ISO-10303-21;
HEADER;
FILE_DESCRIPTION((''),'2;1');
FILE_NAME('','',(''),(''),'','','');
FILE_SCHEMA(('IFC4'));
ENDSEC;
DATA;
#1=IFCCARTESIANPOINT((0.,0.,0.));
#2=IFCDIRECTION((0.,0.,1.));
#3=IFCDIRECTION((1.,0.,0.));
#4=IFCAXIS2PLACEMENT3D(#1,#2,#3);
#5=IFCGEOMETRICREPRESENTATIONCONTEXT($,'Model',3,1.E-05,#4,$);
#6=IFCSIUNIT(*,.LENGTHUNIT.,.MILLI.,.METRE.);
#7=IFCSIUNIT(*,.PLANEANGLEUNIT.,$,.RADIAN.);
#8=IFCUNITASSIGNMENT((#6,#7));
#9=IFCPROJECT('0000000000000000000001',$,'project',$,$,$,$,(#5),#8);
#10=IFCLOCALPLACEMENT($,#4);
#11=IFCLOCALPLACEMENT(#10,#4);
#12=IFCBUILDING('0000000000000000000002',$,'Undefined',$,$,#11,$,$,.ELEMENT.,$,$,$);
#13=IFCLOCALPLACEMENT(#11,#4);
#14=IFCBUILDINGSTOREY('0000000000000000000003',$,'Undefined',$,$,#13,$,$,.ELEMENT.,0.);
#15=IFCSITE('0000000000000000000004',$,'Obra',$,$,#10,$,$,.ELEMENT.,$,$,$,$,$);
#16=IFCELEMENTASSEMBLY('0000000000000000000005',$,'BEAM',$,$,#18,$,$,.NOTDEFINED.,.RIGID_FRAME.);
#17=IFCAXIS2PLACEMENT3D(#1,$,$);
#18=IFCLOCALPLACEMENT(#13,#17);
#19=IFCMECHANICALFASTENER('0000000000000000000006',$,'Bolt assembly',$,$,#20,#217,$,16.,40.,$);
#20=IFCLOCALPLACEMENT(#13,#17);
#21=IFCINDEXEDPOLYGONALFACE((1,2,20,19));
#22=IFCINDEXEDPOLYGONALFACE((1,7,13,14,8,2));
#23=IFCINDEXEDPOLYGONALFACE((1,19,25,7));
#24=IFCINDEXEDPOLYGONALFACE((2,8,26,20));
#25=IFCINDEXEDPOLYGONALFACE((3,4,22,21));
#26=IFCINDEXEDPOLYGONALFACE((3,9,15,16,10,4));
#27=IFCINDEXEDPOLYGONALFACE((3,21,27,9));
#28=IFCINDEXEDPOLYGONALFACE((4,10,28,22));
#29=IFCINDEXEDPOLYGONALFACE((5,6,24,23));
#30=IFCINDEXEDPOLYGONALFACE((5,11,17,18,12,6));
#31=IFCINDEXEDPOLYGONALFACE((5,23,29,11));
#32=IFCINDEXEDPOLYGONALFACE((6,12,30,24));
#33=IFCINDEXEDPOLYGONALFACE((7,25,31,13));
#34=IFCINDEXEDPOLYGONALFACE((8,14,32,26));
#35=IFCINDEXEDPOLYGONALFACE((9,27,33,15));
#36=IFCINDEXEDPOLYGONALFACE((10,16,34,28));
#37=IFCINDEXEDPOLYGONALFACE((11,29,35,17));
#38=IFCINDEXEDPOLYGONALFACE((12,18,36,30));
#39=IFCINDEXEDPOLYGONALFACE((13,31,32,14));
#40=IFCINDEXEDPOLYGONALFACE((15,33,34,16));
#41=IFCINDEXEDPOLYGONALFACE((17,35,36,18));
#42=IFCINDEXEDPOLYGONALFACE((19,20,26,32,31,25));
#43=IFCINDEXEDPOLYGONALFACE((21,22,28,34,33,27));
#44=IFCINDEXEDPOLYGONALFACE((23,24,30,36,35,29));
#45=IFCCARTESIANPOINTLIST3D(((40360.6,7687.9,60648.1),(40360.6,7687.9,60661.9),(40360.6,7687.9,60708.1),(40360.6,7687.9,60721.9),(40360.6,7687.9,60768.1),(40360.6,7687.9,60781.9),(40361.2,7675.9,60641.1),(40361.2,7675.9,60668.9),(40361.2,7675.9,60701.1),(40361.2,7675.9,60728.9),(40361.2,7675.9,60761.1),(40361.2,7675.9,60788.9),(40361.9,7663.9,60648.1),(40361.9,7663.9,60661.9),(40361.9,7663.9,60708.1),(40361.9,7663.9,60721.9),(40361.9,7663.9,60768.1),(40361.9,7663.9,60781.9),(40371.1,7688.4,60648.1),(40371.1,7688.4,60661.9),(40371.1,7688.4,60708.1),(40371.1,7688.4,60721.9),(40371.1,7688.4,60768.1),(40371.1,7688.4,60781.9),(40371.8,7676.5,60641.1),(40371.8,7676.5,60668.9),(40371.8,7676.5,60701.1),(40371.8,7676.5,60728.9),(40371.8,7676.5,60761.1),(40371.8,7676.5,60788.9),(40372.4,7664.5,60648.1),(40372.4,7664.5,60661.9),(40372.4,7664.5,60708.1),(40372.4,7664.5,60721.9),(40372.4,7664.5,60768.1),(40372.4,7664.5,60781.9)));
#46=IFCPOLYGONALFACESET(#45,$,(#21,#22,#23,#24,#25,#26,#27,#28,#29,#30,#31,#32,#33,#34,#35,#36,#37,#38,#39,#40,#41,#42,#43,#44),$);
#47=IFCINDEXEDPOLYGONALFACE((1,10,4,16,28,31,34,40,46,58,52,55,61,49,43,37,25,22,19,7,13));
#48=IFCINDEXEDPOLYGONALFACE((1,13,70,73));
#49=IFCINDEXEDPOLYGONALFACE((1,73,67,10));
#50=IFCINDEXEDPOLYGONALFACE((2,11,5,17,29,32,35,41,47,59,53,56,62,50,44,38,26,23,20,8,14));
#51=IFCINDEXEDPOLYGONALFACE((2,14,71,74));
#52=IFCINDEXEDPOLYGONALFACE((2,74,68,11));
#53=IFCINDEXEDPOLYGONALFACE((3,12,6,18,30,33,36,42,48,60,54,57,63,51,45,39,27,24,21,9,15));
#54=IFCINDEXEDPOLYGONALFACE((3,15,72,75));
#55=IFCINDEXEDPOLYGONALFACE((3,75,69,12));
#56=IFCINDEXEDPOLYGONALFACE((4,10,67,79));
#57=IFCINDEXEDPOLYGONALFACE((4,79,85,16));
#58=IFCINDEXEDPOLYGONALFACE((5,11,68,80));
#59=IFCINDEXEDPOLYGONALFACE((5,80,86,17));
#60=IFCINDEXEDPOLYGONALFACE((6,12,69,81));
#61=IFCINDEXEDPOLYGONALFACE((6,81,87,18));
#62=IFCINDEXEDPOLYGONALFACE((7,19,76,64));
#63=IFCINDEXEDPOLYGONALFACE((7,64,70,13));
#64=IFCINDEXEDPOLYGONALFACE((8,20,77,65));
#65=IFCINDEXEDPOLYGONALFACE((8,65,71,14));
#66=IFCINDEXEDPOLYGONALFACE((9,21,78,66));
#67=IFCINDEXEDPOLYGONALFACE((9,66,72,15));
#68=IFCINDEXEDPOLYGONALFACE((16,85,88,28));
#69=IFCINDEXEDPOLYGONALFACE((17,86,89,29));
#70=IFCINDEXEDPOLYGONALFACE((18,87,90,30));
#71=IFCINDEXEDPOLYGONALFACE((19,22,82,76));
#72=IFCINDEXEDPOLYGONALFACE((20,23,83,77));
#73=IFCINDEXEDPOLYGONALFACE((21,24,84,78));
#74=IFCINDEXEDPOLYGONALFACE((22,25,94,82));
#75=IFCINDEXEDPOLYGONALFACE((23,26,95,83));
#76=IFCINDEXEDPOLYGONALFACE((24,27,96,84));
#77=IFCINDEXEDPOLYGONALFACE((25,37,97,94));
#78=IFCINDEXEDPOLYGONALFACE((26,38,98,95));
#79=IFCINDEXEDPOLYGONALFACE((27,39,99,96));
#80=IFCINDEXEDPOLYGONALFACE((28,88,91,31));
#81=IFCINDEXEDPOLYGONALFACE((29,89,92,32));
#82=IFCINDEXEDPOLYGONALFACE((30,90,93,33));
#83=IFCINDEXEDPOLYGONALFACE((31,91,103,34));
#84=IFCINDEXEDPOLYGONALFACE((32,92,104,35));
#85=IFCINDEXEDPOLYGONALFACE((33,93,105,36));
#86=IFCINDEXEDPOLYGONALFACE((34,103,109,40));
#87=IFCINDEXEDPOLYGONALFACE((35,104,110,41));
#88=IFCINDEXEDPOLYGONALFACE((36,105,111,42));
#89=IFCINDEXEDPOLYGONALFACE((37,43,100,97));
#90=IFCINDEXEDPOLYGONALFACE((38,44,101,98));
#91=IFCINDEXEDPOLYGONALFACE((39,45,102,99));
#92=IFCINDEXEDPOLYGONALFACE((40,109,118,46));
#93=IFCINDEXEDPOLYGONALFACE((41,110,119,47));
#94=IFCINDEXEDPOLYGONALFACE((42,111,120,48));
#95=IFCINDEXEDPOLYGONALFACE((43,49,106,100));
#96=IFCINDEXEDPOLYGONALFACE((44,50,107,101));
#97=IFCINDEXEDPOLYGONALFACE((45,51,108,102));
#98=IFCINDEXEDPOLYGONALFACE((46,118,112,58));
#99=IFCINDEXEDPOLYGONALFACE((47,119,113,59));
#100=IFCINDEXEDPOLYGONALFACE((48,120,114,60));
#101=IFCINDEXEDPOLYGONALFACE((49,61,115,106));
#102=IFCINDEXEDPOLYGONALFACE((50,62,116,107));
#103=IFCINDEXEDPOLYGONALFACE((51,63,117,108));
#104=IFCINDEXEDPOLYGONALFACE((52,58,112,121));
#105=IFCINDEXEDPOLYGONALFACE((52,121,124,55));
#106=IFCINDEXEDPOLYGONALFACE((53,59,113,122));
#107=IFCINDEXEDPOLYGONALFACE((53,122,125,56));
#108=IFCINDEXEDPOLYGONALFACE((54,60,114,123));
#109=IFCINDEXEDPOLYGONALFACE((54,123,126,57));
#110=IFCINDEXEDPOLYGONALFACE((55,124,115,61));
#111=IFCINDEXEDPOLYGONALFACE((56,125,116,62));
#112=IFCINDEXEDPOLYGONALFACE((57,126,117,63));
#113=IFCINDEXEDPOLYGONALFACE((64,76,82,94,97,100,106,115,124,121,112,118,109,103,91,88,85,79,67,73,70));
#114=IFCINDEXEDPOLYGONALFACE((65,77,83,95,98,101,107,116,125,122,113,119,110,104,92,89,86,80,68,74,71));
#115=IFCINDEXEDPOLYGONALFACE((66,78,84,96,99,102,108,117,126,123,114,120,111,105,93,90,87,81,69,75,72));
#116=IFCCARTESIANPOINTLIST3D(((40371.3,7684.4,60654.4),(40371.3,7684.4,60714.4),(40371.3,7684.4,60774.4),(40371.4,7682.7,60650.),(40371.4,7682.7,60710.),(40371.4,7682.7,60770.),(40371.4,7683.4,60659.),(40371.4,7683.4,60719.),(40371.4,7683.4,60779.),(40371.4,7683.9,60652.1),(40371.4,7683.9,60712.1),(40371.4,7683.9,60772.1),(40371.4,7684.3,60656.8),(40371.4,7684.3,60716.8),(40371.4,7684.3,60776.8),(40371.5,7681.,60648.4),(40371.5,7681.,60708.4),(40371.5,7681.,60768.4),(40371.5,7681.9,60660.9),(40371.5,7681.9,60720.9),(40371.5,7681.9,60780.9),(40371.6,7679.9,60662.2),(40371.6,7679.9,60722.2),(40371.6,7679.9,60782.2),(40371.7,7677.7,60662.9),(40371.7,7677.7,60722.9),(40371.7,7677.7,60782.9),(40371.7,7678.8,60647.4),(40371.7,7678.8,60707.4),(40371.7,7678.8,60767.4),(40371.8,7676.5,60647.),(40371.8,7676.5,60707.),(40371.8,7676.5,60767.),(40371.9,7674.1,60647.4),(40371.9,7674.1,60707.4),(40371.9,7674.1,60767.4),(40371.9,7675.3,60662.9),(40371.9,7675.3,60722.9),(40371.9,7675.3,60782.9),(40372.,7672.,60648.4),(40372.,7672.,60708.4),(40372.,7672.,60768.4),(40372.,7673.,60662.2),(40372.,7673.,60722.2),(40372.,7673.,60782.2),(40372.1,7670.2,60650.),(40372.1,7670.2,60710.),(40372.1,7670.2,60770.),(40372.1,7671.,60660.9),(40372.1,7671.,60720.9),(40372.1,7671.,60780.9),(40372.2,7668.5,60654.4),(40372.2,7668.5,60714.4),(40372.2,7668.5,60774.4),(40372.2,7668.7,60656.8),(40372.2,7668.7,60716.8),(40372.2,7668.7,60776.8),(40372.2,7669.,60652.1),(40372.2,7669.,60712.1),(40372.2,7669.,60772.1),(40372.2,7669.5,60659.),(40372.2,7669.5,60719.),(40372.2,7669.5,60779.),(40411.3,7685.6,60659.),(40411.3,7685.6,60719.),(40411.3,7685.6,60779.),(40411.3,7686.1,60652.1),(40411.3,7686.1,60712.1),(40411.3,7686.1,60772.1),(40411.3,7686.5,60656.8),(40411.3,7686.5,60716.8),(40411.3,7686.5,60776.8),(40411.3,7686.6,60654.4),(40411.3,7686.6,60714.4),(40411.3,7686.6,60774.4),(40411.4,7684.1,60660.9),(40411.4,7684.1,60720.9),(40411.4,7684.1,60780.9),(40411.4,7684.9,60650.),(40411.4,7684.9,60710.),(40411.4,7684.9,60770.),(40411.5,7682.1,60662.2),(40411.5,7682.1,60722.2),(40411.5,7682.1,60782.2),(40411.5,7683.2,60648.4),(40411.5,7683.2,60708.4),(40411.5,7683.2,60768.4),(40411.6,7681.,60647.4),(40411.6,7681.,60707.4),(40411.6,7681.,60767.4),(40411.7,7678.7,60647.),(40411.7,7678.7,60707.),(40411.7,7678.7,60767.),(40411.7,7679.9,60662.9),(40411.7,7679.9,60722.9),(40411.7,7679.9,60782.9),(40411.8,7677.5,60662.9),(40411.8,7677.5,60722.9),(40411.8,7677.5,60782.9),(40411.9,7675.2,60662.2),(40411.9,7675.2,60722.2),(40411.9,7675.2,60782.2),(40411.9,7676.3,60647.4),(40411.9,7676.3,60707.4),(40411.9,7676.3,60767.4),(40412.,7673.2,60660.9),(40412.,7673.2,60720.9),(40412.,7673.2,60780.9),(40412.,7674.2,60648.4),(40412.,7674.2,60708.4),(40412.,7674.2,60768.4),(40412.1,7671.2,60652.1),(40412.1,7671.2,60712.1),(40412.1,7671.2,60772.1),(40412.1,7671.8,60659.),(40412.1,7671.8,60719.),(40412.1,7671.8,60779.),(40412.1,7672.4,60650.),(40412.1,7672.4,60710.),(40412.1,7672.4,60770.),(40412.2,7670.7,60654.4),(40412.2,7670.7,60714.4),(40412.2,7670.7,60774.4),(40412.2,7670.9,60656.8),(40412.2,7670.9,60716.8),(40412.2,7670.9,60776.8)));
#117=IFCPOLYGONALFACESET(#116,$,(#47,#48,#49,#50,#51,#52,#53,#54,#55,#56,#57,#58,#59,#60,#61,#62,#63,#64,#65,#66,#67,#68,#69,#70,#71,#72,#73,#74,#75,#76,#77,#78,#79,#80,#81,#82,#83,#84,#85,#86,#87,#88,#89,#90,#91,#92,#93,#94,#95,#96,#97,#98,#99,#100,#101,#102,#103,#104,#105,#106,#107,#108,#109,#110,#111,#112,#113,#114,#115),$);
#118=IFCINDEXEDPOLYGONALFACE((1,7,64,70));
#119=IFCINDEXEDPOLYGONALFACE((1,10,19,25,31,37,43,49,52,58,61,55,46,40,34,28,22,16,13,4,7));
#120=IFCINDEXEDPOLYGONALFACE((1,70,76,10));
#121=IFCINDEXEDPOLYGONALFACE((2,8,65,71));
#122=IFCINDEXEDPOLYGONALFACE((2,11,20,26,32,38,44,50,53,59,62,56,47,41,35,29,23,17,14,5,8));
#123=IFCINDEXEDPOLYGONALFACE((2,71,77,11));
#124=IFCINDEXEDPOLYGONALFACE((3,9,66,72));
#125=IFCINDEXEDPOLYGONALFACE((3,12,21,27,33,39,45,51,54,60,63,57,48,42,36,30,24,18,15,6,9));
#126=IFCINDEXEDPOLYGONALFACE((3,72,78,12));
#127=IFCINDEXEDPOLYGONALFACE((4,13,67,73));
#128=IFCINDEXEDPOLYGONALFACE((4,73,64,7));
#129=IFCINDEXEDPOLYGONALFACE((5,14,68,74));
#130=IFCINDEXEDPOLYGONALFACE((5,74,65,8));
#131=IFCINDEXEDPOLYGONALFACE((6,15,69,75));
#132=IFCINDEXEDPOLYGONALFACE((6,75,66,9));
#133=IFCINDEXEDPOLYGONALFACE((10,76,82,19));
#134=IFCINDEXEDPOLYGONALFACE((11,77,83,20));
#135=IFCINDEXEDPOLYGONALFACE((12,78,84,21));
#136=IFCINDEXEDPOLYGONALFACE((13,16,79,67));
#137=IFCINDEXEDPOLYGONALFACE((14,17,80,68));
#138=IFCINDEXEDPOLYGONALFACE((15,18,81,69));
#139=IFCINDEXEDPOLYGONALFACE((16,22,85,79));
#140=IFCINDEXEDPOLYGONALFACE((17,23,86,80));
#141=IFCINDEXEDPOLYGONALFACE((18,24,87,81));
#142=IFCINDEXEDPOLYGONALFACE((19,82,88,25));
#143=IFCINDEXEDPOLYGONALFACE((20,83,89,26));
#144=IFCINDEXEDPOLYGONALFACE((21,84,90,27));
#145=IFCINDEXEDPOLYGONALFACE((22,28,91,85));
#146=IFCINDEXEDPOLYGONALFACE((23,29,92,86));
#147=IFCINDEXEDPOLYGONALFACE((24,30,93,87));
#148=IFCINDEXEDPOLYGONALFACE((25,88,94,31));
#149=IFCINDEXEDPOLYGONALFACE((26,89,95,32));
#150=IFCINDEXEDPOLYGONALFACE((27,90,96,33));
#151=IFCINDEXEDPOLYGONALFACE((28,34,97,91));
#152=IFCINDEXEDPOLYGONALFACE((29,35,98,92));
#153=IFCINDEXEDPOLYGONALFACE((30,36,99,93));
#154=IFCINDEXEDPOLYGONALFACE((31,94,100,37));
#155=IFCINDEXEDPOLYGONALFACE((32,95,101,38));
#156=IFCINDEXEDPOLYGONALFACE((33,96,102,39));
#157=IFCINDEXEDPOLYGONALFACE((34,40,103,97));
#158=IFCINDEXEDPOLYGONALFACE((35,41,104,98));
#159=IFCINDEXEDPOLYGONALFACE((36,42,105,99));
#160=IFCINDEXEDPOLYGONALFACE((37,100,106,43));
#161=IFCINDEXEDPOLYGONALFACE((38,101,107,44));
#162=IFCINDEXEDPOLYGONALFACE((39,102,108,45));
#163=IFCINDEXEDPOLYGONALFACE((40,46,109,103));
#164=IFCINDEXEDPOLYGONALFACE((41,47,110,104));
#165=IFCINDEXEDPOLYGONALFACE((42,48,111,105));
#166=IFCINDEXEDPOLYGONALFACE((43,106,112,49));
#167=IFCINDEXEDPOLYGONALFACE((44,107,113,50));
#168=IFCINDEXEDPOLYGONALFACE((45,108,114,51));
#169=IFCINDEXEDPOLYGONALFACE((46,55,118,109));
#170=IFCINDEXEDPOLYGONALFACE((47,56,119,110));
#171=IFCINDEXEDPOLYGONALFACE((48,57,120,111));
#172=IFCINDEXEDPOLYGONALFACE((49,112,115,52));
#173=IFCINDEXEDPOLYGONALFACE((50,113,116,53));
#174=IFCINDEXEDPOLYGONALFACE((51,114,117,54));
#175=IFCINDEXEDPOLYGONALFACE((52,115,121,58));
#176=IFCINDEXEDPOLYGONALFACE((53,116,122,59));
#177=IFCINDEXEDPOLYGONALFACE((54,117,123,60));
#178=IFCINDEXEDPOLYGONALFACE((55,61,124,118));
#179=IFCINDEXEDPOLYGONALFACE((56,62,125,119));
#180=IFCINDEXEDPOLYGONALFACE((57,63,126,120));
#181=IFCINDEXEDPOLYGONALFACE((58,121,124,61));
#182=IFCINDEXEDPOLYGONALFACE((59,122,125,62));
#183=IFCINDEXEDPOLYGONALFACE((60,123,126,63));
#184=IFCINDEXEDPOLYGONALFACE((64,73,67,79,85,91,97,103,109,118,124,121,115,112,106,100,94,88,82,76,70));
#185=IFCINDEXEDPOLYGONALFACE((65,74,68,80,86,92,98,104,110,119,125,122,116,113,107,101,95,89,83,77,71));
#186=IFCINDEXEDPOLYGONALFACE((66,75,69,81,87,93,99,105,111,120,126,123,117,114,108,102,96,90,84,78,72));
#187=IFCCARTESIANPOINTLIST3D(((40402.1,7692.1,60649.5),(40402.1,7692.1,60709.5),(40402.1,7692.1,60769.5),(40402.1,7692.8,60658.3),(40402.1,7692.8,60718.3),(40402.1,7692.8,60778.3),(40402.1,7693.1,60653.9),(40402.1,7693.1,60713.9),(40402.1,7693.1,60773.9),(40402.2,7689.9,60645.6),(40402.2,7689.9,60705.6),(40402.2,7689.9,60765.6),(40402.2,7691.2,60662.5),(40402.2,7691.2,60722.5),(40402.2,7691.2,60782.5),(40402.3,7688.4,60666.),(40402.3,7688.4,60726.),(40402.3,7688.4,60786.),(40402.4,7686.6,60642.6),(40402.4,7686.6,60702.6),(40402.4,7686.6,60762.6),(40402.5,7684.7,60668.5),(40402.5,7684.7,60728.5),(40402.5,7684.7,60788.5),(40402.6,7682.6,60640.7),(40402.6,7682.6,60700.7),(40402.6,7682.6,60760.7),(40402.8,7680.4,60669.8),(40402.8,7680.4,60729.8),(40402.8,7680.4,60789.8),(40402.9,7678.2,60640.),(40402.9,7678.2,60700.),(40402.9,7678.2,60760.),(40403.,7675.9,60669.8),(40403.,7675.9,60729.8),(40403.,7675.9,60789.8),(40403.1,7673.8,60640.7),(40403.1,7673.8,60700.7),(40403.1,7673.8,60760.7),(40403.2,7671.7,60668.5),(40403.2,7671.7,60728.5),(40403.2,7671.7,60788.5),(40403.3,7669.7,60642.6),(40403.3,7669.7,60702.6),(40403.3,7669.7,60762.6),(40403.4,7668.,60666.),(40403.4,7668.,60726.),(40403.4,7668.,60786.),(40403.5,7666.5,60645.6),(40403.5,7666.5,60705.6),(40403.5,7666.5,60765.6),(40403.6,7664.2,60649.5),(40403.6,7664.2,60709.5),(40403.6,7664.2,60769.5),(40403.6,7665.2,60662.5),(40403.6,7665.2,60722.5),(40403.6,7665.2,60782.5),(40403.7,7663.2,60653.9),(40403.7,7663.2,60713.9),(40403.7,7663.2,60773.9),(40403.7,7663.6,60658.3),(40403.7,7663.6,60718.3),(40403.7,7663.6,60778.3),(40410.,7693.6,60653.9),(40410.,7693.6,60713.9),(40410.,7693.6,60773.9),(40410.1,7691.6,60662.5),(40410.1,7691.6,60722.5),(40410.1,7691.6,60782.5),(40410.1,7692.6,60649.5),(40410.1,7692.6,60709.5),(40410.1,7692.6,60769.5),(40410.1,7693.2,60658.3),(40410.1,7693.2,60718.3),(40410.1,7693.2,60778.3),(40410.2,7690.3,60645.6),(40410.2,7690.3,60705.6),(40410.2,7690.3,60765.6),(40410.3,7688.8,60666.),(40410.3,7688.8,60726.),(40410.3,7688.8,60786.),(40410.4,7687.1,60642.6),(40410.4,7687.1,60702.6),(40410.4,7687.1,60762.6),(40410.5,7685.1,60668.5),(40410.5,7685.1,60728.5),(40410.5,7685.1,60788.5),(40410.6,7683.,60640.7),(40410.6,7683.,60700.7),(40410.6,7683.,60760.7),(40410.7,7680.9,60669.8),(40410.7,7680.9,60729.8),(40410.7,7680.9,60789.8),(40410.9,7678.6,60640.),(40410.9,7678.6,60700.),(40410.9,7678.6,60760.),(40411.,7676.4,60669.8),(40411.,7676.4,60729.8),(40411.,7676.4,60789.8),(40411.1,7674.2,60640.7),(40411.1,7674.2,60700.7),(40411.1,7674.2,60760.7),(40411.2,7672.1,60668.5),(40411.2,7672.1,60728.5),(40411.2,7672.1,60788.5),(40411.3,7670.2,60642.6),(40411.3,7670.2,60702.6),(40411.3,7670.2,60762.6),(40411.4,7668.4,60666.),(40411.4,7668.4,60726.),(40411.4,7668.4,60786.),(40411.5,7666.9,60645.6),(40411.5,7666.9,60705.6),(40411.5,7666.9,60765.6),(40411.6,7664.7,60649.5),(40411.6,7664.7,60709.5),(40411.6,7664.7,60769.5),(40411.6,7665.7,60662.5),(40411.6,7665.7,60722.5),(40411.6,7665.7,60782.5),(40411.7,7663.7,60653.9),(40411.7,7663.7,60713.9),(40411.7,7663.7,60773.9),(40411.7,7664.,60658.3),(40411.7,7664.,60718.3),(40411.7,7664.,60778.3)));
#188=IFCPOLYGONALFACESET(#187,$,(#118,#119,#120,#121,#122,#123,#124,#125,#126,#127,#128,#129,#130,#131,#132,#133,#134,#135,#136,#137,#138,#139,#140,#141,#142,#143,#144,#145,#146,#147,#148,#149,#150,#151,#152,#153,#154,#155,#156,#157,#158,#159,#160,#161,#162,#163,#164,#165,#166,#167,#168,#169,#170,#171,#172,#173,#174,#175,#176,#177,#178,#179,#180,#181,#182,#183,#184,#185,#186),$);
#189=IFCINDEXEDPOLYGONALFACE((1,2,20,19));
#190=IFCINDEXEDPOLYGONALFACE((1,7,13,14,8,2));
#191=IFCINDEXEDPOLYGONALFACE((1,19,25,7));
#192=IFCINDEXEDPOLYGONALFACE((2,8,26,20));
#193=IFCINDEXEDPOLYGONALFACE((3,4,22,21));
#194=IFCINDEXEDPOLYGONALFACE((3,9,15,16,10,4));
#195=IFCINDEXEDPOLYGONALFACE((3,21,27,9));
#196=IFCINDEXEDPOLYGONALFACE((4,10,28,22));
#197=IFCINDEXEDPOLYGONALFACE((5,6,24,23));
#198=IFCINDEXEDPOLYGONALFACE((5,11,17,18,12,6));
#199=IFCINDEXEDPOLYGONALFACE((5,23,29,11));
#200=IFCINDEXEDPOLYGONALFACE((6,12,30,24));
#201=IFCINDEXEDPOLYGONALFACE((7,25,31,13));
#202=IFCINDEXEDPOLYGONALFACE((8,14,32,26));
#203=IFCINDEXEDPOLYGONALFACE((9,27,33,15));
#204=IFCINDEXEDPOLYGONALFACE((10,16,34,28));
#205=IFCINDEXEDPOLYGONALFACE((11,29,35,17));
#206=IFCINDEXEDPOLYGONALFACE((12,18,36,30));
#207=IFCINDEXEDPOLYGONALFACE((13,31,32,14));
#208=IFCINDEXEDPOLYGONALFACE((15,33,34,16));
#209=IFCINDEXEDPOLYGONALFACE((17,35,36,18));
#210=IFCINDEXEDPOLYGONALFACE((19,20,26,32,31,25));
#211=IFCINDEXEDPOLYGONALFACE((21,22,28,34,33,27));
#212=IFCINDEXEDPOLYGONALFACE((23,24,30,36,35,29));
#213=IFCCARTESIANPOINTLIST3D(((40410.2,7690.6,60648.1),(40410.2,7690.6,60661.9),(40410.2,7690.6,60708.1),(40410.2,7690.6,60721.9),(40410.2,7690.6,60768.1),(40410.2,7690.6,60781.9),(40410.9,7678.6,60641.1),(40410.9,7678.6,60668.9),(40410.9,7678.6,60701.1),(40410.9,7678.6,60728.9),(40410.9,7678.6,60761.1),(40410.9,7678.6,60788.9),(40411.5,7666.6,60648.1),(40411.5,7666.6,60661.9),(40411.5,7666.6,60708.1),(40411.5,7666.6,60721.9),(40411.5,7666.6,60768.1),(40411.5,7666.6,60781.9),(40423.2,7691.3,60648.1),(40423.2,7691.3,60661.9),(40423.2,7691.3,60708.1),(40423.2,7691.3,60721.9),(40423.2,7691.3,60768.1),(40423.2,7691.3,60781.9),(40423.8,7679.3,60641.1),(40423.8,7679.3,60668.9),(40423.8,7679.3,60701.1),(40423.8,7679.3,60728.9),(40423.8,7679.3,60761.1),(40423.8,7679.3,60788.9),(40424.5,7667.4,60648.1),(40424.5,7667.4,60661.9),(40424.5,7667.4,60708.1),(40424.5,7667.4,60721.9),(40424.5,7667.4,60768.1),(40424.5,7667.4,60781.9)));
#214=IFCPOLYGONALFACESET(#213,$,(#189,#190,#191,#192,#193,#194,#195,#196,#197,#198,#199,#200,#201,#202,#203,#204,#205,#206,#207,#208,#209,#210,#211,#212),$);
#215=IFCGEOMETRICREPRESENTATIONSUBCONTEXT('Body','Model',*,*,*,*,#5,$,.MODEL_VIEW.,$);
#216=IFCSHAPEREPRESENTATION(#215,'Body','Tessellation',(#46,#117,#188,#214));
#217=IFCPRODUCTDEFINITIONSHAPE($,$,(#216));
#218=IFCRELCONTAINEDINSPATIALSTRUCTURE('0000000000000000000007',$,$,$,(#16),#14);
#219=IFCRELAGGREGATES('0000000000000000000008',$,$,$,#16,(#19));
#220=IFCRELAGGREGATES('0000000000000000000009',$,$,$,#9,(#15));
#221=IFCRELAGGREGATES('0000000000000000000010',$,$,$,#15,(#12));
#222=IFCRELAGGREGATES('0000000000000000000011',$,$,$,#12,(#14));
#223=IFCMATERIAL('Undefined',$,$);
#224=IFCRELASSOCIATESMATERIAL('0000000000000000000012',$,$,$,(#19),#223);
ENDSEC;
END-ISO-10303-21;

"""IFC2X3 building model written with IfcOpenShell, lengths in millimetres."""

from ifc_helpers import new_model, si_unit, frame, origin_with_axes, origin_2d_with_axis, place, context, subcontext, project, spatial, polyline, circle, outline, extrude, source, transform, mapped, material, element, aggregate, save


model = new_model("IFC2X3")

# Units and contexts
model_context = context("Model", 3, precision=1e-05, world=origin_with_axes())
body_context = subcontext(model_context, "Body", "Model", "MODEL_VIEW")
ifc_project = project(units=[si_unit("LENGTHUNIT", "METRE", prefix="MILLI"), si_unit("PLANEANGLEUNIT", "RADIAN")], contexts=[model_context])

# Site, building, storey
site_placement = place(None, origin_with_axes())
site = spatial("IfcSite", under=ifc_project, at=site_placement, Name="Obra", CompositionType="ELEMENT")
building_placement = place(site_placement, origin_with_axes())
building = spatial("IfcBuilding", under=site, at=building_placement, Name="Undefined", CompositionType="ELEMENT")
storey_placement = place(building_placement, origin_with_axes())
storey = spatial("IfcBuildingStorey", under=building, at=storey_placement, Name="Undefined", CompositionType="ELEMENT", Elevation=0.0)

# Element assembly, mechanical fastener
assembly_1_placement = place(storey_placement, origin_with_axes())
assembly_1 = element("IfcElementAssembly", 1, at=assembly_1_placement, inside=storey, Name="BEAM", AssemblyPlace="NOTDEFINED", PredefinedType="RIGID_FRAME")
ifc_material_1 = material(Name="Undefined")
shared_shape_1 = source(origin_with_axes(), body_context, "Body", "SweptSolid", [
    extrude(outline(polyline([(13.9, 0.0), (6.9, 12.0), (-6.9, 12.0), (-13.9, 0.0), (-6.9, -12.0), (6.9, -12.0), (13.9, 0.0)])), frame((0.0, -44.8, 0.0), z_axis=(0.0, 1.0, 0.0), x_axis=(1.0, 0.0, 0.0)), (0.0, 0.0, 1.0), 10.6),
    extrude(circle(Radius=8.0, at=origin_2d_with_axis()), frame((0.0, -34.2, 0.0), z_axis=(0.0, 1.0, 0.0), x_axis=(1.0, 0.0, 0.0)), (0.0, 0.0, 1.0), 40.0),
    extrude(circle(Radius=15.0, at=origin_2d_with_axis()), frame((0.0, -3.1, 0.0), z_axis=(0.0, 1.0, 0.0), x_axis=(1.0, 0.0, 0.0)), (0.0, 0.0, 1.0), 8.0),
    extrude(outline(polyline([(13.9, 0.0), (6.9, 12.0), (-6.9, 12.0), (-13.9, 0.0), (-6.9, -12.0), (6.9, -12.0), (13.9, 0.0)])), frame((0.0, 4.9, 0.0), z_axis=(0.0, 1.0, 0.0), x_axis=(1.0, 0.0, 0.0)), (0.0, 0.0, 1.0), 13.0),
])
mechanical_fastener_1_placement = place(assembly_1_placement, frame((40403.2, 7728.3, 60835.0), z_axis=(0.055152, -0.998478, 0.0), x_axis=(0.0, 0.0, -1.0)))
mechanical_fastener_1 = element("IfcMechanicalFastener", 2, at=mechanical_fastener_1_placement, material=ifc_material_1, Name="Bolt assembly", NominalDiameter=16.0, NominalLength=40.0, context=body_context, shape_type="MappedRepresentation", body=[
    mapped(shared_shape_1, transform((60.0, 0.0, 50.0))),
    mapped(shared_shape_1, transform((120.0, 0.0, 50.0))),
    mapped(shared_shape_1, transform((180.0, 0.0, 50.0))),
])

aggregate(assembly_1, [mechanical_fastener_1])

save(model, "model.ifc")
